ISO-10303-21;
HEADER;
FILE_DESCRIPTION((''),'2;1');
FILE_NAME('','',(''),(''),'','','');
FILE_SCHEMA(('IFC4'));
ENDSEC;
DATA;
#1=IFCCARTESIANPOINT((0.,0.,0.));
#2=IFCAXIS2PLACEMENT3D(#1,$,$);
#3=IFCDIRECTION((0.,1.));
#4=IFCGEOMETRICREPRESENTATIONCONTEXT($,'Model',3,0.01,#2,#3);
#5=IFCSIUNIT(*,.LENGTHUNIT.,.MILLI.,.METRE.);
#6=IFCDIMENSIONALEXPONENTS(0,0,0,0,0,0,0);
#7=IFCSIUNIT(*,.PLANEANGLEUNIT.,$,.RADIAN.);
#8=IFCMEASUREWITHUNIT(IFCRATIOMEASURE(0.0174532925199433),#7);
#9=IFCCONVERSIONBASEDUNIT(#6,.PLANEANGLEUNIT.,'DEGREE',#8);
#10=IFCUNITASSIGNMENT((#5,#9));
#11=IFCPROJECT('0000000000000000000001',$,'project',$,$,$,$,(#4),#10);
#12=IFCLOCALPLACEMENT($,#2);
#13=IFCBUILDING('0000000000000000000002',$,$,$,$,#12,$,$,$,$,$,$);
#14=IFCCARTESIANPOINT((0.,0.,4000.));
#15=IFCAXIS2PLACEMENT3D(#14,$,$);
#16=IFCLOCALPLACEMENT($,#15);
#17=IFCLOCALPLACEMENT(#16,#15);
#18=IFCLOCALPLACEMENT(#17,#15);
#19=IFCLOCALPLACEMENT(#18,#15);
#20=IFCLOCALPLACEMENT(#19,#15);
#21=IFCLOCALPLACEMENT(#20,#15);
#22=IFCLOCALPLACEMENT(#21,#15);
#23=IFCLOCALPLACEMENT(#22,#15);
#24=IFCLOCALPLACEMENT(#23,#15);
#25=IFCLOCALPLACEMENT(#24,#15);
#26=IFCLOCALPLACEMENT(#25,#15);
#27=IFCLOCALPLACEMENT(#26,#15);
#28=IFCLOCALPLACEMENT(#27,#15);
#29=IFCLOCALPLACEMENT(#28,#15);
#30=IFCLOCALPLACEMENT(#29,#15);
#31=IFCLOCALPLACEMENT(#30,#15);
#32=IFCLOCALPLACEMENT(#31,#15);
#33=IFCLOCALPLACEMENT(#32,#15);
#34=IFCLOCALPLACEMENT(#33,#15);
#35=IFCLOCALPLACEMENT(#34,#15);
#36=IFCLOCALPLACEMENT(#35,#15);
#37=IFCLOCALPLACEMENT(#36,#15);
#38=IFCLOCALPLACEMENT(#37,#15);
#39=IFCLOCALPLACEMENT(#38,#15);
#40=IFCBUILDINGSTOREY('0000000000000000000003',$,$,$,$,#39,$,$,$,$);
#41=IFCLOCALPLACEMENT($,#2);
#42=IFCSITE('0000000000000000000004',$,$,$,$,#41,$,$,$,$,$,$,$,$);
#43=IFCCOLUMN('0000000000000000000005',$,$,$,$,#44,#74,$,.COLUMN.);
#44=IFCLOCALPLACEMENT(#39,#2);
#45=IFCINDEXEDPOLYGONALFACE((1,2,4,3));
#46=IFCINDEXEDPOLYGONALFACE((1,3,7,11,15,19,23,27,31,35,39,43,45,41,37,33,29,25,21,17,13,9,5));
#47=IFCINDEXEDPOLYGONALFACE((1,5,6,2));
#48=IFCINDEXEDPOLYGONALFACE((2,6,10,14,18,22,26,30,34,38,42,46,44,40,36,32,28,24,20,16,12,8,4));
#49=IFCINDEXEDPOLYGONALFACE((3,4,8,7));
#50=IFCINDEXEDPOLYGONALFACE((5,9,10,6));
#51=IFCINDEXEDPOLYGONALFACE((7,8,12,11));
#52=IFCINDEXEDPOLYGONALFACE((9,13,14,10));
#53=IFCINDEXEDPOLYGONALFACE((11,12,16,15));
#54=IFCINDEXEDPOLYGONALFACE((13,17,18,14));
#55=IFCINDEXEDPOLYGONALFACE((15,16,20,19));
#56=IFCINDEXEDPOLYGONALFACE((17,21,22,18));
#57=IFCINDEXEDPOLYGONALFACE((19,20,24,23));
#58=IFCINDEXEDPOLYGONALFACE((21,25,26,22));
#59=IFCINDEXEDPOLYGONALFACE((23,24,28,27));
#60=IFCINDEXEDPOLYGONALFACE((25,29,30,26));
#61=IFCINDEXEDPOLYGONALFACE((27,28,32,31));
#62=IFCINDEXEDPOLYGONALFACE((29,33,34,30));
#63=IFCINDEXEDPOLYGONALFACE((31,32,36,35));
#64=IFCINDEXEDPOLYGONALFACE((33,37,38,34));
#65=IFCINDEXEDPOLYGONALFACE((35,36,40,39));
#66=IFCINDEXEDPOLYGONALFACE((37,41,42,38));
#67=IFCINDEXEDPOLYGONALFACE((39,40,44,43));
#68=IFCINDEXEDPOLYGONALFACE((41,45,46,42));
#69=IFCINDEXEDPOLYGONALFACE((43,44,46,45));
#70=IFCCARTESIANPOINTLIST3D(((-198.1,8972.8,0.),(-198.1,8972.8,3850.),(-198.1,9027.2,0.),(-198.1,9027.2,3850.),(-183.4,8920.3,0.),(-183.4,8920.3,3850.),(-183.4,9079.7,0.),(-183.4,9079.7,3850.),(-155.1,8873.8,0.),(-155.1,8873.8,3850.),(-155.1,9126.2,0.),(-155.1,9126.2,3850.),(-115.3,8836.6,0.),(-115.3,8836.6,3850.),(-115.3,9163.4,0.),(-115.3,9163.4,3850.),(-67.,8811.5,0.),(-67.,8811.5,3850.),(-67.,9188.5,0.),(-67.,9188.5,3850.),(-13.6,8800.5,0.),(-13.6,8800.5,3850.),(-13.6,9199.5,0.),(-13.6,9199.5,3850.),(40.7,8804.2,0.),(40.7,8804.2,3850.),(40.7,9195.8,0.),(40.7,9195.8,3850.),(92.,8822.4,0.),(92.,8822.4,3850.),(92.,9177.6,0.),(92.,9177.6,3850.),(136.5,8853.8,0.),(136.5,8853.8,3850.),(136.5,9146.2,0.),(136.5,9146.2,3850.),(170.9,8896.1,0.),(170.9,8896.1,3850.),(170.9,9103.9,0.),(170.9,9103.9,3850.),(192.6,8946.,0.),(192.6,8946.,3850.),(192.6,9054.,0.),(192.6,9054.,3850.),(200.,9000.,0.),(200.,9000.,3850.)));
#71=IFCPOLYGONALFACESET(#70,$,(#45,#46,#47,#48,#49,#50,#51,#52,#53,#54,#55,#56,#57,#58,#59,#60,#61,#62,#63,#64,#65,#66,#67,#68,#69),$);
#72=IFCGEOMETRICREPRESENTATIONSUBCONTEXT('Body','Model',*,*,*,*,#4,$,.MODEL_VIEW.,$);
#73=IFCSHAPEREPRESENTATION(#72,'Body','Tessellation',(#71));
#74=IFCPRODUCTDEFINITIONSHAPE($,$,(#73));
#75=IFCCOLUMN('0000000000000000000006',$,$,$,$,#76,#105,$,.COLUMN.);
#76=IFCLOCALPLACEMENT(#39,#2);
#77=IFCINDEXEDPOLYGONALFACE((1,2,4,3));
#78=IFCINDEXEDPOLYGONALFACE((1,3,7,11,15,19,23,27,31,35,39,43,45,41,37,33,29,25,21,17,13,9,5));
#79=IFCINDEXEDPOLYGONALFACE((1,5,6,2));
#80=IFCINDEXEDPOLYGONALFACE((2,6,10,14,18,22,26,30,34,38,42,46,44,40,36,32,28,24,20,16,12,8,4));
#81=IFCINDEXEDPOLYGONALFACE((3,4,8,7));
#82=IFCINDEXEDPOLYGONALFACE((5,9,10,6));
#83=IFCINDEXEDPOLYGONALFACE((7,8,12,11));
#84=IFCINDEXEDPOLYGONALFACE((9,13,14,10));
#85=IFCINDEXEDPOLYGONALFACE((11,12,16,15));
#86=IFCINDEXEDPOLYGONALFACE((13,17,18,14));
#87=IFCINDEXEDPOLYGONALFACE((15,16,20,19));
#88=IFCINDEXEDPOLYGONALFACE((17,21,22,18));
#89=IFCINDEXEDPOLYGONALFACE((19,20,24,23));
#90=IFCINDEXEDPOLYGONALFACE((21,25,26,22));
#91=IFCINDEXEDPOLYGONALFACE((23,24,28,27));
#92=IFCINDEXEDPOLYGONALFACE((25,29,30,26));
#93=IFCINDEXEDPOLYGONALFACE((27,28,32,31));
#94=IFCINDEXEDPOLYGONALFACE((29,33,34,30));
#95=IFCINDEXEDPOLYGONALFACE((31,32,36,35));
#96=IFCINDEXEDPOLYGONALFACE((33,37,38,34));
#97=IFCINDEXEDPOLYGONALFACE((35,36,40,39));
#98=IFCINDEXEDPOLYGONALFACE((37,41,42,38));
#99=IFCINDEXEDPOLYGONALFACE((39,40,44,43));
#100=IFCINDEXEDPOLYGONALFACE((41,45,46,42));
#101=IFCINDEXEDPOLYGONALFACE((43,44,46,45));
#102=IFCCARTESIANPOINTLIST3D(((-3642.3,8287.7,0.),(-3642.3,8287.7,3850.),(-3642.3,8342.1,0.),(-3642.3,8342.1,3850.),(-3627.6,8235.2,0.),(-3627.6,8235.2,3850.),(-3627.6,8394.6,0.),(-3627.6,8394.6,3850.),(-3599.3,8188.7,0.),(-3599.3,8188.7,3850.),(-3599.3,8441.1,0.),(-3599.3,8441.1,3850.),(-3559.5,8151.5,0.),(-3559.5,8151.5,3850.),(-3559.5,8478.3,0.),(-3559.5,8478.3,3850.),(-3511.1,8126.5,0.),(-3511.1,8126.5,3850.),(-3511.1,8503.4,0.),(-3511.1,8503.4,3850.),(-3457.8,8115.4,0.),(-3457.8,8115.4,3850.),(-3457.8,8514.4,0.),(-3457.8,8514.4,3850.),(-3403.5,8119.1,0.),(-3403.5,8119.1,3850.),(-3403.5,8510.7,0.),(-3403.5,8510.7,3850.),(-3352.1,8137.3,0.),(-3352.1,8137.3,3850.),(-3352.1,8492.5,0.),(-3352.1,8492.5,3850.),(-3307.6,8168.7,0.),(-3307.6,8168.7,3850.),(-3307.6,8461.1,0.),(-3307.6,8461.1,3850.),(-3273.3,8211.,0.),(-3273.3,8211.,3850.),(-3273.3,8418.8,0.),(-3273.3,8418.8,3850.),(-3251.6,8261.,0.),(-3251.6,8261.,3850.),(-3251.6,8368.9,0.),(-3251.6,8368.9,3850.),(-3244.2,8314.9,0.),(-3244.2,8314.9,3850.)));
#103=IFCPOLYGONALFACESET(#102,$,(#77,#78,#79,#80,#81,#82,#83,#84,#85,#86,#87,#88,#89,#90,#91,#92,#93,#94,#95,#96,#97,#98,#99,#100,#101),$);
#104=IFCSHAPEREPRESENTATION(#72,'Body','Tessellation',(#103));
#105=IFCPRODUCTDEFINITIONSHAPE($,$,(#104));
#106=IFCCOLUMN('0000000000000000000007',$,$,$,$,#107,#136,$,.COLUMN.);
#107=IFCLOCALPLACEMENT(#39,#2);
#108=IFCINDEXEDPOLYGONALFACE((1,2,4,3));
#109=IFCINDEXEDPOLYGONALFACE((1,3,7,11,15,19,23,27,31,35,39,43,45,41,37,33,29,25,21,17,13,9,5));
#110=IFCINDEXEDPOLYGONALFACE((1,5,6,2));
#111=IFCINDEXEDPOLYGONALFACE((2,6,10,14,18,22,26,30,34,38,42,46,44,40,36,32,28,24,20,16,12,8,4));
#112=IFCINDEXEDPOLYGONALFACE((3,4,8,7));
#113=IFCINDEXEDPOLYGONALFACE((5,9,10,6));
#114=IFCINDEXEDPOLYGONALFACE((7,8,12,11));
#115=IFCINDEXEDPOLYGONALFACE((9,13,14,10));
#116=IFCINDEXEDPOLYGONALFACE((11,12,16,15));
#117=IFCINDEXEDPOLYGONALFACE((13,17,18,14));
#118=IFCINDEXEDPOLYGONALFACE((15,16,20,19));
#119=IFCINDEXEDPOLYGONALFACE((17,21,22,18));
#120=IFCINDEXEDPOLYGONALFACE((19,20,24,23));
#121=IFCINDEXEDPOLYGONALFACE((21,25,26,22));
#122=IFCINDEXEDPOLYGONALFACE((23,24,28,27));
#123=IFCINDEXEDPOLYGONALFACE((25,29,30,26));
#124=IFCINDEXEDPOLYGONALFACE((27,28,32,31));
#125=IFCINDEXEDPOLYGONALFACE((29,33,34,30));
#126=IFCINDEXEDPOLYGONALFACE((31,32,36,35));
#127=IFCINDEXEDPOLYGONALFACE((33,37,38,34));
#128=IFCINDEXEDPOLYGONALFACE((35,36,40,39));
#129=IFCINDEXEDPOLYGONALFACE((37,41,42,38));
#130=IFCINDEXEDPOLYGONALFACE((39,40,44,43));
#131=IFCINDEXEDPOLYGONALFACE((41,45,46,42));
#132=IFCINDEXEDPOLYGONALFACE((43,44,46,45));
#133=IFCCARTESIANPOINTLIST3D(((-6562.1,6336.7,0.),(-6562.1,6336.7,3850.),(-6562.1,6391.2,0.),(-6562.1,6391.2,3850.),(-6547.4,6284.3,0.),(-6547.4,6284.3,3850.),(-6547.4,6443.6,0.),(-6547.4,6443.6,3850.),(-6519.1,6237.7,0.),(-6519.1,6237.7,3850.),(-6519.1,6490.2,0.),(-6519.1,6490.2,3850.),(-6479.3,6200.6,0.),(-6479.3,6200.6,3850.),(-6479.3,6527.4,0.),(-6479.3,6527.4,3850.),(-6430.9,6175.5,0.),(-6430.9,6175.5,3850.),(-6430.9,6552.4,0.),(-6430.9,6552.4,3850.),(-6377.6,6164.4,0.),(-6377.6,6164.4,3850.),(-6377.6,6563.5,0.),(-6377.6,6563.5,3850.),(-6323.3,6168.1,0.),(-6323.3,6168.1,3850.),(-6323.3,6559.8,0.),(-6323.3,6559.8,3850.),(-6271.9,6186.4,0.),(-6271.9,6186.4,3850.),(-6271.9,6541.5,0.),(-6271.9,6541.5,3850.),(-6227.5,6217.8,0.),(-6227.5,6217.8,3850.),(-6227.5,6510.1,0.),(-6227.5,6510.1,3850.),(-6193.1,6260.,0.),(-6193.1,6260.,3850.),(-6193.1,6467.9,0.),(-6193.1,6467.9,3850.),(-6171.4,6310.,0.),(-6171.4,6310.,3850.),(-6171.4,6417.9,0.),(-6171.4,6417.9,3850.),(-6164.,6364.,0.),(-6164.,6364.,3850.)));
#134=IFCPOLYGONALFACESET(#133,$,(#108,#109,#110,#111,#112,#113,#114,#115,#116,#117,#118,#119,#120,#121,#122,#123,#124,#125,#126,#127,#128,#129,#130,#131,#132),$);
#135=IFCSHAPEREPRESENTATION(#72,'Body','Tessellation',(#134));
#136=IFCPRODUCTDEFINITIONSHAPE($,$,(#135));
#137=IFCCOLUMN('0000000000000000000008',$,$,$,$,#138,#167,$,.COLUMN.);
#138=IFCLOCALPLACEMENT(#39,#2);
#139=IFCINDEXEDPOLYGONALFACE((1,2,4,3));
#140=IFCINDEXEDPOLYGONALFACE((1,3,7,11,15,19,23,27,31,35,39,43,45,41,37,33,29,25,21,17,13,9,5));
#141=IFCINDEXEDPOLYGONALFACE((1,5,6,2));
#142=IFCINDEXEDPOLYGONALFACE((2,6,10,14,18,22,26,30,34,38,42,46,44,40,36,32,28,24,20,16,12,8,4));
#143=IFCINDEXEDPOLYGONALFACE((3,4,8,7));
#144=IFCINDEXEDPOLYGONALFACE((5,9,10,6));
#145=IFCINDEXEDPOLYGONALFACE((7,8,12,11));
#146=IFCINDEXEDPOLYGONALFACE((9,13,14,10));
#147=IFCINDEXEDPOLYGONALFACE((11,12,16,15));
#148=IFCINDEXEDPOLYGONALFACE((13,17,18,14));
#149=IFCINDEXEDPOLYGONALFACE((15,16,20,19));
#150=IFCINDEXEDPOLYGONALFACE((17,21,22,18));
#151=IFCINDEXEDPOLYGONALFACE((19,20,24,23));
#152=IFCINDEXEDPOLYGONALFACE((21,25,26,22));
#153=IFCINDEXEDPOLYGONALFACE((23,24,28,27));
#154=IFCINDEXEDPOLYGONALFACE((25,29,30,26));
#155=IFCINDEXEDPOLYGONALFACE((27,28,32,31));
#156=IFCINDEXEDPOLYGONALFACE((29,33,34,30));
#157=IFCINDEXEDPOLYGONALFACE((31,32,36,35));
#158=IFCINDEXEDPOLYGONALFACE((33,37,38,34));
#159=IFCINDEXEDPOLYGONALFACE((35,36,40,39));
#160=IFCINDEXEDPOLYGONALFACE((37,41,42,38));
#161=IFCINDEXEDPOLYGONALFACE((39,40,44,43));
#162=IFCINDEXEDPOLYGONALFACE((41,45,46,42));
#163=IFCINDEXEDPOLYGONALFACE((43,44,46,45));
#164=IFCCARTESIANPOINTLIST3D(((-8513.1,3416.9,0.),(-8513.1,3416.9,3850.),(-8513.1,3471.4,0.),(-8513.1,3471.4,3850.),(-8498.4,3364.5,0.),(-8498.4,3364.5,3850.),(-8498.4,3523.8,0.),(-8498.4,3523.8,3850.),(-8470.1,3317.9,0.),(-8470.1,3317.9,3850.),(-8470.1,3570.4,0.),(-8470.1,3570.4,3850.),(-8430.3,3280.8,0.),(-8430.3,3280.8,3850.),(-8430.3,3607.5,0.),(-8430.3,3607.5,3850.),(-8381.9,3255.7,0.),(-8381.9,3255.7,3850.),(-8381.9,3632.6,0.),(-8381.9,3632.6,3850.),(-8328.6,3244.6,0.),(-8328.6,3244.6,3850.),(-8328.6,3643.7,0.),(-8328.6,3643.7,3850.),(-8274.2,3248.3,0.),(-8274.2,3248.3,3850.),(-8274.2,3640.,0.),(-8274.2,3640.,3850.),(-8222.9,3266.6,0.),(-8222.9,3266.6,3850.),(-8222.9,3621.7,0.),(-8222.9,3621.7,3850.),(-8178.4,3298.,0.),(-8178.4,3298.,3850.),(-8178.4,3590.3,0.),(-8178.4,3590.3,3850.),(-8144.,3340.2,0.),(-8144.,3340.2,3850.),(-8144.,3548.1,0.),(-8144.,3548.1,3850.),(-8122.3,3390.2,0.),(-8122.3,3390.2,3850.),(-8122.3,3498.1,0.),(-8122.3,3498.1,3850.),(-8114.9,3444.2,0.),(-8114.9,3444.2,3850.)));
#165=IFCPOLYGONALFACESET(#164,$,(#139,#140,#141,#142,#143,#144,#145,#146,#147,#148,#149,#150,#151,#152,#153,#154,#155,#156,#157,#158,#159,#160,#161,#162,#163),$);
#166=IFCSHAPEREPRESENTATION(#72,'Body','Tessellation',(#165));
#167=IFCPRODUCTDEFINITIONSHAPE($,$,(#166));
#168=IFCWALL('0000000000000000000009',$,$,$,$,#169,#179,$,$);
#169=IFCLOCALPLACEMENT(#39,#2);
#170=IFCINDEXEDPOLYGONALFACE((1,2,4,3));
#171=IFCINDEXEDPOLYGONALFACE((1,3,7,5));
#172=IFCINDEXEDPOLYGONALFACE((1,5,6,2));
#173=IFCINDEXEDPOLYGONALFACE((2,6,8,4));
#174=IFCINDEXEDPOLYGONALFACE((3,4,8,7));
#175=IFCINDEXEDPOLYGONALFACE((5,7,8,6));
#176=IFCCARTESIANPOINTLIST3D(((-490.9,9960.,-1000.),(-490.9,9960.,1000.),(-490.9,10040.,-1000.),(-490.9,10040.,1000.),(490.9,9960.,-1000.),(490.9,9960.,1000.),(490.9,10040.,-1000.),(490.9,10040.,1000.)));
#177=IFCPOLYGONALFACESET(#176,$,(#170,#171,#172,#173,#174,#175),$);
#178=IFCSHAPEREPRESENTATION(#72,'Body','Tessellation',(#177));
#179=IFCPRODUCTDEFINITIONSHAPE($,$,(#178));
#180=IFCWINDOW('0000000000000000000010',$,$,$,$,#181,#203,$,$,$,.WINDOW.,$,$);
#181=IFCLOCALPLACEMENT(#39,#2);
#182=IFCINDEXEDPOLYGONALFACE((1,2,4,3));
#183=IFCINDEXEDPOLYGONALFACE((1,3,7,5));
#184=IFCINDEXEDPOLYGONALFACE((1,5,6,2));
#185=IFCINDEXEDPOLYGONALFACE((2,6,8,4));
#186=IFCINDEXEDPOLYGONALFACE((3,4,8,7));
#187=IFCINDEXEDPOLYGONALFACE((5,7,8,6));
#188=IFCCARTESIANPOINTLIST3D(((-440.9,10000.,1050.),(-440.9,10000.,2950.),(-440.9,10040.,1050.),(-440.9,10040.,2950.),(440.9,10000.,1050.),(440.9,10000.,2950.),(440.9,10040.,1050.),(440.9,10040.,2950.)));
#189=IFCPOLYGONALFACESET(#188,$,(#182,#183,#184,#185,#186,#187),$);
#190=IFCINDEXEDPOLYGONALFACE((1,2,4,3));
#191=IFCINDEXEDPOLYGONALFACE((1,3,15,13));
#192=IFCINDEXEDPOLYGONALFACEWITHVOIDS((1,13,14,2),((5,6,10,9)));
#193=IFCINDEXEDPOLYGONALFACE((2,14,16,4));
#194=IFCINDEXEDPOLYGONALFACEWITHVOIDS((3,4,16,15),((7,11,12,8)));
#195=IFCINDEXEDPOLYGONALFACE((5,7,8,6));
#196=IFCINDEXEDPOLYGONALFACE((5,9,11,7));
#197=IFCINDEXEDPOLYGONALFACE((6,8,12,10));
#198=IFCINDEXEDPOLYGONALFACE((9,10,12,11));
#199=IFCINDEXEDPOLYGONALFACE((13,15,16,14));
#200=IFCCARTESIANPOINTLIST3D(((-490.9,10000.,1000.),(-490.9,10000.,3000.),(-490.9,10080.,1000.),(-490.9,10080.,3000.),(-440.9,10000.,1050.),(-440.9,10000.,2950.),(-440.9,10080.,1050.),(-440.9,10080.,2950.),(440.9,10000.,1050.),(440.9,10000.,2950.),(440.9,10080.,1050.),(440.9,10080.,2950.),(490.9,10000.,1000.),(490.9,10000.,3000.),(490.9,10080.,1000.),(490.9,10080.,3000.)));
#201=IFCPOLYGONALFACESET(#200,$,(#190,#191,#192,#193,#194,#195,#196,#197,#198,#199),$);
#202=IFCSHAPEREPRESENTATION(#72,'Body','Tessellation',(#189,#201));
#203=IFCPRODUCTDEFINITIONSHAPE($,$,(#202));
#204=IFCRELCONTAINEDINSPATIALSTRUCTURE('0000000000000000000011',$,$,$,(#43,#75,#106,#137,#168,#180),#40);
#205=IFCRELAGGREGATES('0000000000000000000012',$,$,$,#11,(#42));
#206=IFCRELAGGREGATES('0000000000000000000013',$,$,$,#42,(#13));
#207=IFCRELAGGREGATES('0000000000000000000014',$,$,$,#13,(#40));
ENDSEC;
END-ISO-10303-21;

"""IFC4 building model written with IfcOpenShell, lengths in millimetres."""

from ifc_helpers import new_model, entity, si_unit, converted_unit, direction, frame, origin, origin_2d, place, context, subcontext, project, spatial, rectangle, circle, extrude, element, save


model = new_model("IFC4")

# Units and contexts
model_context = context("Model", 3, precision=0.01, world=origin(), true_north=direction((0.0, 1.0)))
body_context = subcontext(model_context, "Body", "Model", "MODEL_VIEW")
ifc_project = project(units=[si_unit("LENGTHUNIT", "METRE", prefix="MILLI"), converted_unit("PLANEANGLEUNIT", "DEGREE", entity("IfcRatioMeasure", 0.0174532925199433), si_unit("PLANEANGLEUNIT", "RADIAN"), dimensions=[0, 0, 0, 0, 0, 0, 0])], contexts=[model_context])

# Site, building, storey
site_placement = place(None, origin())
site = spatial("IfcSite", under=ifc_project, at=site_placement)
building_placement = place(None, origin())
building = spatial("IfcBuilding", under=site, at=building_placement)
placement_1 = place(None, frame((0.0, 0.0, 4000.0)))
placement_2 = place(placement_1, frame((0.0, 0.0, 4000.0)))
placement_3 = place(placement_2, frame((0.0, 0.0, 4000.0)))
placement_4 = place(placement_3, frame((0.0, 0.0, 4000.0)))
placement_5 = place(placement_4, frame((0.0, 0.0, 4000.0)))
placement_6 = place(placement_5, frame((0.0, 0.0, 4000.0)))
placement_7 = place(placement_6, frame((0.0, 0.0, 4000.0)))
placement_8 = place(placement_7, frame((0.0, 0.0, 4000.0)))
placement_9 = place(placement_8, frame((0.0, 0.0, 4000.0)))
placement_10 = place(placement_9, frame((0.0, 0.0, 4000.0)))
placement_11 = place(placement_10, frame((0.0, 0.0, 4000.0)))
placement_12 = place(placement_11, frame((0.0, 0.0, 4000.0)))
placement_13 = place(placement_12, frame((0.0, 0.0, 4000.0)))
placement_14 = place(placement_13, frame((0.0, 0.0, 4000.0)))
placement_15 = place(placement_14, frame((0.0, 0.0, 4000.0)))
placement_16 = place(placement_15, frame((0.0, 0.0, 4000.0)))
placement_17 = place(placement_16, frame((0.0, 0.0, 4000.0)))
placement_18 = place(placement_17, frame((0.0, 0.0, 4000.0)))
placement_19 = place(placement_18, frame((0.0, 0.0, 4000.0)))
placement_20 = place(placement_19, frame((0.0, 0.0, 4000.0)))
placement_21 = place(placement_20, frame((0.0, 0.0, 4000.0)))
placement_22 = place(placement_21, frame((0.0, 0.0, 4000.0)))
placement_23 = place(placement_22, frame((0.0, 0.0, 4000.0)))
storey_placement = place(placement_23, frame((0.0, 0.0, 4000.0)))
storey = spatial("IfcBuildingStorey", under=building, at=storey_placement)

# Columns
for number, where in (
    (1, (0.0, 9000.0, 0.0)),
    (2, (-3444.2, 8314.9, 0.0)),
    (3, (-6364.0, 6364.0, 0.0)),
    (4, (-8314.9, 3444.2, 0.0)),
):
    element("IfcColumn", number, at=place(storey_placement, frame(where)), inside=storey, PredefinedType="COLUMN", context=body_context, shape_type="SweptSolid", body=[
        extrude(circle(Radius=200.0, at=origin_2d()), origin(), (0.0, 0.0, 1.0), 3850.0),
    ])

# Wall
wall_1_placement = place(storey_placement, frame((0.0, 10000.0, -1000.0), z_axis=(0.0, 0.0, 1.0), x_axis=(-10000.0, -0.000437, 0.0)))
element("IfcWall", 5, at=wall_1_placement, inside=storey, context=body_context, shape_type="SweptSolid", body=[
    extrude(rectangle(XDim=981.7, YDim=80.0, at=origin_2d()), origin(), (0.0, 0.0, 1.0), 2000.0),
])

# Window
cartesian_point_1 = entity("IfcCartesianPoint", [-440.9, -950.0])
shared_polyline = entity("IfcPolyline", [cartesian_point_1, entity("IfcCartesianPoint", [-440.9, 950.0]), entity("IfcCartesianPoint", [-440.9, 950.0]), entity("IfcCartesianPoint", [440.9, 950.0]), entity("IfcCartesianPoint", [440.9, 950.0]), entity("IfcCartesianPoint", [440.9, -950.0]), entity("IfcCartesianPoint", [440.9, -950.0]), entity("IfcCartesianPoint", [-440.9, -950.0]), cartesian_point_1])
window_1_placement = place(storey_placement, frame((0.0, 10000.0, 2000.0), z_axis=(0.0, 0.0, 1.0), x_axis=(-10000.0, -0.000437, 0.0)))
cartesian_point_2 = entity("IfcCartesianPoint", [-490.9, -1000.0])
element("IfcWindow", 6, at=window_1_placement, inside=storey, PredefinedType="WINDOW", context=body_context, shape_type="SweptSolid", body=[
    entity("IfcExtrudedAreaSolid", entity("IfcArbitraryClosedProfileDef", "AREA", None, shared_polyline), entity("IfcAxis2Placement3D", entity("IfcCartesianPoint", [0.0, 0.0, 0.0]), entity("IfcDirection", [0.0, -1.0, 0.0]), entity("IfcDirection", [1.0, 0.0, 0.0])), entity("IfcDirection", [0.0, 0.0, 1.0]), 40.0),
    entity("IfcExtrudedAreaSolid", entity("IfcArbitraryProfileDefWithVoids", "AREA", None, entity("IfcPolyline", [cartesian_point_2, entity("IfcCartesianPoint", [-490.9, 1000.0]), entity("IfcCartesianPoint", [-490.9, 1000.0]), entity("IfcCartesianPoint", [490.9, 1000.0]), entity("IfcCartesianPoint", [490.9, 1000.0]), entity("IfcCartesianPoint", [490.9, -1000.0]), entity("IfcCartesianPoint", [490.9, -1000.0]), entity("IfcCartesianPoint", [-490.9, -1000.0]), cartesian_point_2]), [shared_polyline]), entity("IfcAxis2Placement3D", entity("IfcCartesianPoint", [0.0, 0.0, 0.0]), entity("IfcDirection", [0.0, -1.0, 0.0]), entity("IfcDirection", [1.0, 0.0, 0.0])), entity("IfcDirection", [0.0, 0.0, 1.0]), 80.0),
])

save(model, "model.ifc")
